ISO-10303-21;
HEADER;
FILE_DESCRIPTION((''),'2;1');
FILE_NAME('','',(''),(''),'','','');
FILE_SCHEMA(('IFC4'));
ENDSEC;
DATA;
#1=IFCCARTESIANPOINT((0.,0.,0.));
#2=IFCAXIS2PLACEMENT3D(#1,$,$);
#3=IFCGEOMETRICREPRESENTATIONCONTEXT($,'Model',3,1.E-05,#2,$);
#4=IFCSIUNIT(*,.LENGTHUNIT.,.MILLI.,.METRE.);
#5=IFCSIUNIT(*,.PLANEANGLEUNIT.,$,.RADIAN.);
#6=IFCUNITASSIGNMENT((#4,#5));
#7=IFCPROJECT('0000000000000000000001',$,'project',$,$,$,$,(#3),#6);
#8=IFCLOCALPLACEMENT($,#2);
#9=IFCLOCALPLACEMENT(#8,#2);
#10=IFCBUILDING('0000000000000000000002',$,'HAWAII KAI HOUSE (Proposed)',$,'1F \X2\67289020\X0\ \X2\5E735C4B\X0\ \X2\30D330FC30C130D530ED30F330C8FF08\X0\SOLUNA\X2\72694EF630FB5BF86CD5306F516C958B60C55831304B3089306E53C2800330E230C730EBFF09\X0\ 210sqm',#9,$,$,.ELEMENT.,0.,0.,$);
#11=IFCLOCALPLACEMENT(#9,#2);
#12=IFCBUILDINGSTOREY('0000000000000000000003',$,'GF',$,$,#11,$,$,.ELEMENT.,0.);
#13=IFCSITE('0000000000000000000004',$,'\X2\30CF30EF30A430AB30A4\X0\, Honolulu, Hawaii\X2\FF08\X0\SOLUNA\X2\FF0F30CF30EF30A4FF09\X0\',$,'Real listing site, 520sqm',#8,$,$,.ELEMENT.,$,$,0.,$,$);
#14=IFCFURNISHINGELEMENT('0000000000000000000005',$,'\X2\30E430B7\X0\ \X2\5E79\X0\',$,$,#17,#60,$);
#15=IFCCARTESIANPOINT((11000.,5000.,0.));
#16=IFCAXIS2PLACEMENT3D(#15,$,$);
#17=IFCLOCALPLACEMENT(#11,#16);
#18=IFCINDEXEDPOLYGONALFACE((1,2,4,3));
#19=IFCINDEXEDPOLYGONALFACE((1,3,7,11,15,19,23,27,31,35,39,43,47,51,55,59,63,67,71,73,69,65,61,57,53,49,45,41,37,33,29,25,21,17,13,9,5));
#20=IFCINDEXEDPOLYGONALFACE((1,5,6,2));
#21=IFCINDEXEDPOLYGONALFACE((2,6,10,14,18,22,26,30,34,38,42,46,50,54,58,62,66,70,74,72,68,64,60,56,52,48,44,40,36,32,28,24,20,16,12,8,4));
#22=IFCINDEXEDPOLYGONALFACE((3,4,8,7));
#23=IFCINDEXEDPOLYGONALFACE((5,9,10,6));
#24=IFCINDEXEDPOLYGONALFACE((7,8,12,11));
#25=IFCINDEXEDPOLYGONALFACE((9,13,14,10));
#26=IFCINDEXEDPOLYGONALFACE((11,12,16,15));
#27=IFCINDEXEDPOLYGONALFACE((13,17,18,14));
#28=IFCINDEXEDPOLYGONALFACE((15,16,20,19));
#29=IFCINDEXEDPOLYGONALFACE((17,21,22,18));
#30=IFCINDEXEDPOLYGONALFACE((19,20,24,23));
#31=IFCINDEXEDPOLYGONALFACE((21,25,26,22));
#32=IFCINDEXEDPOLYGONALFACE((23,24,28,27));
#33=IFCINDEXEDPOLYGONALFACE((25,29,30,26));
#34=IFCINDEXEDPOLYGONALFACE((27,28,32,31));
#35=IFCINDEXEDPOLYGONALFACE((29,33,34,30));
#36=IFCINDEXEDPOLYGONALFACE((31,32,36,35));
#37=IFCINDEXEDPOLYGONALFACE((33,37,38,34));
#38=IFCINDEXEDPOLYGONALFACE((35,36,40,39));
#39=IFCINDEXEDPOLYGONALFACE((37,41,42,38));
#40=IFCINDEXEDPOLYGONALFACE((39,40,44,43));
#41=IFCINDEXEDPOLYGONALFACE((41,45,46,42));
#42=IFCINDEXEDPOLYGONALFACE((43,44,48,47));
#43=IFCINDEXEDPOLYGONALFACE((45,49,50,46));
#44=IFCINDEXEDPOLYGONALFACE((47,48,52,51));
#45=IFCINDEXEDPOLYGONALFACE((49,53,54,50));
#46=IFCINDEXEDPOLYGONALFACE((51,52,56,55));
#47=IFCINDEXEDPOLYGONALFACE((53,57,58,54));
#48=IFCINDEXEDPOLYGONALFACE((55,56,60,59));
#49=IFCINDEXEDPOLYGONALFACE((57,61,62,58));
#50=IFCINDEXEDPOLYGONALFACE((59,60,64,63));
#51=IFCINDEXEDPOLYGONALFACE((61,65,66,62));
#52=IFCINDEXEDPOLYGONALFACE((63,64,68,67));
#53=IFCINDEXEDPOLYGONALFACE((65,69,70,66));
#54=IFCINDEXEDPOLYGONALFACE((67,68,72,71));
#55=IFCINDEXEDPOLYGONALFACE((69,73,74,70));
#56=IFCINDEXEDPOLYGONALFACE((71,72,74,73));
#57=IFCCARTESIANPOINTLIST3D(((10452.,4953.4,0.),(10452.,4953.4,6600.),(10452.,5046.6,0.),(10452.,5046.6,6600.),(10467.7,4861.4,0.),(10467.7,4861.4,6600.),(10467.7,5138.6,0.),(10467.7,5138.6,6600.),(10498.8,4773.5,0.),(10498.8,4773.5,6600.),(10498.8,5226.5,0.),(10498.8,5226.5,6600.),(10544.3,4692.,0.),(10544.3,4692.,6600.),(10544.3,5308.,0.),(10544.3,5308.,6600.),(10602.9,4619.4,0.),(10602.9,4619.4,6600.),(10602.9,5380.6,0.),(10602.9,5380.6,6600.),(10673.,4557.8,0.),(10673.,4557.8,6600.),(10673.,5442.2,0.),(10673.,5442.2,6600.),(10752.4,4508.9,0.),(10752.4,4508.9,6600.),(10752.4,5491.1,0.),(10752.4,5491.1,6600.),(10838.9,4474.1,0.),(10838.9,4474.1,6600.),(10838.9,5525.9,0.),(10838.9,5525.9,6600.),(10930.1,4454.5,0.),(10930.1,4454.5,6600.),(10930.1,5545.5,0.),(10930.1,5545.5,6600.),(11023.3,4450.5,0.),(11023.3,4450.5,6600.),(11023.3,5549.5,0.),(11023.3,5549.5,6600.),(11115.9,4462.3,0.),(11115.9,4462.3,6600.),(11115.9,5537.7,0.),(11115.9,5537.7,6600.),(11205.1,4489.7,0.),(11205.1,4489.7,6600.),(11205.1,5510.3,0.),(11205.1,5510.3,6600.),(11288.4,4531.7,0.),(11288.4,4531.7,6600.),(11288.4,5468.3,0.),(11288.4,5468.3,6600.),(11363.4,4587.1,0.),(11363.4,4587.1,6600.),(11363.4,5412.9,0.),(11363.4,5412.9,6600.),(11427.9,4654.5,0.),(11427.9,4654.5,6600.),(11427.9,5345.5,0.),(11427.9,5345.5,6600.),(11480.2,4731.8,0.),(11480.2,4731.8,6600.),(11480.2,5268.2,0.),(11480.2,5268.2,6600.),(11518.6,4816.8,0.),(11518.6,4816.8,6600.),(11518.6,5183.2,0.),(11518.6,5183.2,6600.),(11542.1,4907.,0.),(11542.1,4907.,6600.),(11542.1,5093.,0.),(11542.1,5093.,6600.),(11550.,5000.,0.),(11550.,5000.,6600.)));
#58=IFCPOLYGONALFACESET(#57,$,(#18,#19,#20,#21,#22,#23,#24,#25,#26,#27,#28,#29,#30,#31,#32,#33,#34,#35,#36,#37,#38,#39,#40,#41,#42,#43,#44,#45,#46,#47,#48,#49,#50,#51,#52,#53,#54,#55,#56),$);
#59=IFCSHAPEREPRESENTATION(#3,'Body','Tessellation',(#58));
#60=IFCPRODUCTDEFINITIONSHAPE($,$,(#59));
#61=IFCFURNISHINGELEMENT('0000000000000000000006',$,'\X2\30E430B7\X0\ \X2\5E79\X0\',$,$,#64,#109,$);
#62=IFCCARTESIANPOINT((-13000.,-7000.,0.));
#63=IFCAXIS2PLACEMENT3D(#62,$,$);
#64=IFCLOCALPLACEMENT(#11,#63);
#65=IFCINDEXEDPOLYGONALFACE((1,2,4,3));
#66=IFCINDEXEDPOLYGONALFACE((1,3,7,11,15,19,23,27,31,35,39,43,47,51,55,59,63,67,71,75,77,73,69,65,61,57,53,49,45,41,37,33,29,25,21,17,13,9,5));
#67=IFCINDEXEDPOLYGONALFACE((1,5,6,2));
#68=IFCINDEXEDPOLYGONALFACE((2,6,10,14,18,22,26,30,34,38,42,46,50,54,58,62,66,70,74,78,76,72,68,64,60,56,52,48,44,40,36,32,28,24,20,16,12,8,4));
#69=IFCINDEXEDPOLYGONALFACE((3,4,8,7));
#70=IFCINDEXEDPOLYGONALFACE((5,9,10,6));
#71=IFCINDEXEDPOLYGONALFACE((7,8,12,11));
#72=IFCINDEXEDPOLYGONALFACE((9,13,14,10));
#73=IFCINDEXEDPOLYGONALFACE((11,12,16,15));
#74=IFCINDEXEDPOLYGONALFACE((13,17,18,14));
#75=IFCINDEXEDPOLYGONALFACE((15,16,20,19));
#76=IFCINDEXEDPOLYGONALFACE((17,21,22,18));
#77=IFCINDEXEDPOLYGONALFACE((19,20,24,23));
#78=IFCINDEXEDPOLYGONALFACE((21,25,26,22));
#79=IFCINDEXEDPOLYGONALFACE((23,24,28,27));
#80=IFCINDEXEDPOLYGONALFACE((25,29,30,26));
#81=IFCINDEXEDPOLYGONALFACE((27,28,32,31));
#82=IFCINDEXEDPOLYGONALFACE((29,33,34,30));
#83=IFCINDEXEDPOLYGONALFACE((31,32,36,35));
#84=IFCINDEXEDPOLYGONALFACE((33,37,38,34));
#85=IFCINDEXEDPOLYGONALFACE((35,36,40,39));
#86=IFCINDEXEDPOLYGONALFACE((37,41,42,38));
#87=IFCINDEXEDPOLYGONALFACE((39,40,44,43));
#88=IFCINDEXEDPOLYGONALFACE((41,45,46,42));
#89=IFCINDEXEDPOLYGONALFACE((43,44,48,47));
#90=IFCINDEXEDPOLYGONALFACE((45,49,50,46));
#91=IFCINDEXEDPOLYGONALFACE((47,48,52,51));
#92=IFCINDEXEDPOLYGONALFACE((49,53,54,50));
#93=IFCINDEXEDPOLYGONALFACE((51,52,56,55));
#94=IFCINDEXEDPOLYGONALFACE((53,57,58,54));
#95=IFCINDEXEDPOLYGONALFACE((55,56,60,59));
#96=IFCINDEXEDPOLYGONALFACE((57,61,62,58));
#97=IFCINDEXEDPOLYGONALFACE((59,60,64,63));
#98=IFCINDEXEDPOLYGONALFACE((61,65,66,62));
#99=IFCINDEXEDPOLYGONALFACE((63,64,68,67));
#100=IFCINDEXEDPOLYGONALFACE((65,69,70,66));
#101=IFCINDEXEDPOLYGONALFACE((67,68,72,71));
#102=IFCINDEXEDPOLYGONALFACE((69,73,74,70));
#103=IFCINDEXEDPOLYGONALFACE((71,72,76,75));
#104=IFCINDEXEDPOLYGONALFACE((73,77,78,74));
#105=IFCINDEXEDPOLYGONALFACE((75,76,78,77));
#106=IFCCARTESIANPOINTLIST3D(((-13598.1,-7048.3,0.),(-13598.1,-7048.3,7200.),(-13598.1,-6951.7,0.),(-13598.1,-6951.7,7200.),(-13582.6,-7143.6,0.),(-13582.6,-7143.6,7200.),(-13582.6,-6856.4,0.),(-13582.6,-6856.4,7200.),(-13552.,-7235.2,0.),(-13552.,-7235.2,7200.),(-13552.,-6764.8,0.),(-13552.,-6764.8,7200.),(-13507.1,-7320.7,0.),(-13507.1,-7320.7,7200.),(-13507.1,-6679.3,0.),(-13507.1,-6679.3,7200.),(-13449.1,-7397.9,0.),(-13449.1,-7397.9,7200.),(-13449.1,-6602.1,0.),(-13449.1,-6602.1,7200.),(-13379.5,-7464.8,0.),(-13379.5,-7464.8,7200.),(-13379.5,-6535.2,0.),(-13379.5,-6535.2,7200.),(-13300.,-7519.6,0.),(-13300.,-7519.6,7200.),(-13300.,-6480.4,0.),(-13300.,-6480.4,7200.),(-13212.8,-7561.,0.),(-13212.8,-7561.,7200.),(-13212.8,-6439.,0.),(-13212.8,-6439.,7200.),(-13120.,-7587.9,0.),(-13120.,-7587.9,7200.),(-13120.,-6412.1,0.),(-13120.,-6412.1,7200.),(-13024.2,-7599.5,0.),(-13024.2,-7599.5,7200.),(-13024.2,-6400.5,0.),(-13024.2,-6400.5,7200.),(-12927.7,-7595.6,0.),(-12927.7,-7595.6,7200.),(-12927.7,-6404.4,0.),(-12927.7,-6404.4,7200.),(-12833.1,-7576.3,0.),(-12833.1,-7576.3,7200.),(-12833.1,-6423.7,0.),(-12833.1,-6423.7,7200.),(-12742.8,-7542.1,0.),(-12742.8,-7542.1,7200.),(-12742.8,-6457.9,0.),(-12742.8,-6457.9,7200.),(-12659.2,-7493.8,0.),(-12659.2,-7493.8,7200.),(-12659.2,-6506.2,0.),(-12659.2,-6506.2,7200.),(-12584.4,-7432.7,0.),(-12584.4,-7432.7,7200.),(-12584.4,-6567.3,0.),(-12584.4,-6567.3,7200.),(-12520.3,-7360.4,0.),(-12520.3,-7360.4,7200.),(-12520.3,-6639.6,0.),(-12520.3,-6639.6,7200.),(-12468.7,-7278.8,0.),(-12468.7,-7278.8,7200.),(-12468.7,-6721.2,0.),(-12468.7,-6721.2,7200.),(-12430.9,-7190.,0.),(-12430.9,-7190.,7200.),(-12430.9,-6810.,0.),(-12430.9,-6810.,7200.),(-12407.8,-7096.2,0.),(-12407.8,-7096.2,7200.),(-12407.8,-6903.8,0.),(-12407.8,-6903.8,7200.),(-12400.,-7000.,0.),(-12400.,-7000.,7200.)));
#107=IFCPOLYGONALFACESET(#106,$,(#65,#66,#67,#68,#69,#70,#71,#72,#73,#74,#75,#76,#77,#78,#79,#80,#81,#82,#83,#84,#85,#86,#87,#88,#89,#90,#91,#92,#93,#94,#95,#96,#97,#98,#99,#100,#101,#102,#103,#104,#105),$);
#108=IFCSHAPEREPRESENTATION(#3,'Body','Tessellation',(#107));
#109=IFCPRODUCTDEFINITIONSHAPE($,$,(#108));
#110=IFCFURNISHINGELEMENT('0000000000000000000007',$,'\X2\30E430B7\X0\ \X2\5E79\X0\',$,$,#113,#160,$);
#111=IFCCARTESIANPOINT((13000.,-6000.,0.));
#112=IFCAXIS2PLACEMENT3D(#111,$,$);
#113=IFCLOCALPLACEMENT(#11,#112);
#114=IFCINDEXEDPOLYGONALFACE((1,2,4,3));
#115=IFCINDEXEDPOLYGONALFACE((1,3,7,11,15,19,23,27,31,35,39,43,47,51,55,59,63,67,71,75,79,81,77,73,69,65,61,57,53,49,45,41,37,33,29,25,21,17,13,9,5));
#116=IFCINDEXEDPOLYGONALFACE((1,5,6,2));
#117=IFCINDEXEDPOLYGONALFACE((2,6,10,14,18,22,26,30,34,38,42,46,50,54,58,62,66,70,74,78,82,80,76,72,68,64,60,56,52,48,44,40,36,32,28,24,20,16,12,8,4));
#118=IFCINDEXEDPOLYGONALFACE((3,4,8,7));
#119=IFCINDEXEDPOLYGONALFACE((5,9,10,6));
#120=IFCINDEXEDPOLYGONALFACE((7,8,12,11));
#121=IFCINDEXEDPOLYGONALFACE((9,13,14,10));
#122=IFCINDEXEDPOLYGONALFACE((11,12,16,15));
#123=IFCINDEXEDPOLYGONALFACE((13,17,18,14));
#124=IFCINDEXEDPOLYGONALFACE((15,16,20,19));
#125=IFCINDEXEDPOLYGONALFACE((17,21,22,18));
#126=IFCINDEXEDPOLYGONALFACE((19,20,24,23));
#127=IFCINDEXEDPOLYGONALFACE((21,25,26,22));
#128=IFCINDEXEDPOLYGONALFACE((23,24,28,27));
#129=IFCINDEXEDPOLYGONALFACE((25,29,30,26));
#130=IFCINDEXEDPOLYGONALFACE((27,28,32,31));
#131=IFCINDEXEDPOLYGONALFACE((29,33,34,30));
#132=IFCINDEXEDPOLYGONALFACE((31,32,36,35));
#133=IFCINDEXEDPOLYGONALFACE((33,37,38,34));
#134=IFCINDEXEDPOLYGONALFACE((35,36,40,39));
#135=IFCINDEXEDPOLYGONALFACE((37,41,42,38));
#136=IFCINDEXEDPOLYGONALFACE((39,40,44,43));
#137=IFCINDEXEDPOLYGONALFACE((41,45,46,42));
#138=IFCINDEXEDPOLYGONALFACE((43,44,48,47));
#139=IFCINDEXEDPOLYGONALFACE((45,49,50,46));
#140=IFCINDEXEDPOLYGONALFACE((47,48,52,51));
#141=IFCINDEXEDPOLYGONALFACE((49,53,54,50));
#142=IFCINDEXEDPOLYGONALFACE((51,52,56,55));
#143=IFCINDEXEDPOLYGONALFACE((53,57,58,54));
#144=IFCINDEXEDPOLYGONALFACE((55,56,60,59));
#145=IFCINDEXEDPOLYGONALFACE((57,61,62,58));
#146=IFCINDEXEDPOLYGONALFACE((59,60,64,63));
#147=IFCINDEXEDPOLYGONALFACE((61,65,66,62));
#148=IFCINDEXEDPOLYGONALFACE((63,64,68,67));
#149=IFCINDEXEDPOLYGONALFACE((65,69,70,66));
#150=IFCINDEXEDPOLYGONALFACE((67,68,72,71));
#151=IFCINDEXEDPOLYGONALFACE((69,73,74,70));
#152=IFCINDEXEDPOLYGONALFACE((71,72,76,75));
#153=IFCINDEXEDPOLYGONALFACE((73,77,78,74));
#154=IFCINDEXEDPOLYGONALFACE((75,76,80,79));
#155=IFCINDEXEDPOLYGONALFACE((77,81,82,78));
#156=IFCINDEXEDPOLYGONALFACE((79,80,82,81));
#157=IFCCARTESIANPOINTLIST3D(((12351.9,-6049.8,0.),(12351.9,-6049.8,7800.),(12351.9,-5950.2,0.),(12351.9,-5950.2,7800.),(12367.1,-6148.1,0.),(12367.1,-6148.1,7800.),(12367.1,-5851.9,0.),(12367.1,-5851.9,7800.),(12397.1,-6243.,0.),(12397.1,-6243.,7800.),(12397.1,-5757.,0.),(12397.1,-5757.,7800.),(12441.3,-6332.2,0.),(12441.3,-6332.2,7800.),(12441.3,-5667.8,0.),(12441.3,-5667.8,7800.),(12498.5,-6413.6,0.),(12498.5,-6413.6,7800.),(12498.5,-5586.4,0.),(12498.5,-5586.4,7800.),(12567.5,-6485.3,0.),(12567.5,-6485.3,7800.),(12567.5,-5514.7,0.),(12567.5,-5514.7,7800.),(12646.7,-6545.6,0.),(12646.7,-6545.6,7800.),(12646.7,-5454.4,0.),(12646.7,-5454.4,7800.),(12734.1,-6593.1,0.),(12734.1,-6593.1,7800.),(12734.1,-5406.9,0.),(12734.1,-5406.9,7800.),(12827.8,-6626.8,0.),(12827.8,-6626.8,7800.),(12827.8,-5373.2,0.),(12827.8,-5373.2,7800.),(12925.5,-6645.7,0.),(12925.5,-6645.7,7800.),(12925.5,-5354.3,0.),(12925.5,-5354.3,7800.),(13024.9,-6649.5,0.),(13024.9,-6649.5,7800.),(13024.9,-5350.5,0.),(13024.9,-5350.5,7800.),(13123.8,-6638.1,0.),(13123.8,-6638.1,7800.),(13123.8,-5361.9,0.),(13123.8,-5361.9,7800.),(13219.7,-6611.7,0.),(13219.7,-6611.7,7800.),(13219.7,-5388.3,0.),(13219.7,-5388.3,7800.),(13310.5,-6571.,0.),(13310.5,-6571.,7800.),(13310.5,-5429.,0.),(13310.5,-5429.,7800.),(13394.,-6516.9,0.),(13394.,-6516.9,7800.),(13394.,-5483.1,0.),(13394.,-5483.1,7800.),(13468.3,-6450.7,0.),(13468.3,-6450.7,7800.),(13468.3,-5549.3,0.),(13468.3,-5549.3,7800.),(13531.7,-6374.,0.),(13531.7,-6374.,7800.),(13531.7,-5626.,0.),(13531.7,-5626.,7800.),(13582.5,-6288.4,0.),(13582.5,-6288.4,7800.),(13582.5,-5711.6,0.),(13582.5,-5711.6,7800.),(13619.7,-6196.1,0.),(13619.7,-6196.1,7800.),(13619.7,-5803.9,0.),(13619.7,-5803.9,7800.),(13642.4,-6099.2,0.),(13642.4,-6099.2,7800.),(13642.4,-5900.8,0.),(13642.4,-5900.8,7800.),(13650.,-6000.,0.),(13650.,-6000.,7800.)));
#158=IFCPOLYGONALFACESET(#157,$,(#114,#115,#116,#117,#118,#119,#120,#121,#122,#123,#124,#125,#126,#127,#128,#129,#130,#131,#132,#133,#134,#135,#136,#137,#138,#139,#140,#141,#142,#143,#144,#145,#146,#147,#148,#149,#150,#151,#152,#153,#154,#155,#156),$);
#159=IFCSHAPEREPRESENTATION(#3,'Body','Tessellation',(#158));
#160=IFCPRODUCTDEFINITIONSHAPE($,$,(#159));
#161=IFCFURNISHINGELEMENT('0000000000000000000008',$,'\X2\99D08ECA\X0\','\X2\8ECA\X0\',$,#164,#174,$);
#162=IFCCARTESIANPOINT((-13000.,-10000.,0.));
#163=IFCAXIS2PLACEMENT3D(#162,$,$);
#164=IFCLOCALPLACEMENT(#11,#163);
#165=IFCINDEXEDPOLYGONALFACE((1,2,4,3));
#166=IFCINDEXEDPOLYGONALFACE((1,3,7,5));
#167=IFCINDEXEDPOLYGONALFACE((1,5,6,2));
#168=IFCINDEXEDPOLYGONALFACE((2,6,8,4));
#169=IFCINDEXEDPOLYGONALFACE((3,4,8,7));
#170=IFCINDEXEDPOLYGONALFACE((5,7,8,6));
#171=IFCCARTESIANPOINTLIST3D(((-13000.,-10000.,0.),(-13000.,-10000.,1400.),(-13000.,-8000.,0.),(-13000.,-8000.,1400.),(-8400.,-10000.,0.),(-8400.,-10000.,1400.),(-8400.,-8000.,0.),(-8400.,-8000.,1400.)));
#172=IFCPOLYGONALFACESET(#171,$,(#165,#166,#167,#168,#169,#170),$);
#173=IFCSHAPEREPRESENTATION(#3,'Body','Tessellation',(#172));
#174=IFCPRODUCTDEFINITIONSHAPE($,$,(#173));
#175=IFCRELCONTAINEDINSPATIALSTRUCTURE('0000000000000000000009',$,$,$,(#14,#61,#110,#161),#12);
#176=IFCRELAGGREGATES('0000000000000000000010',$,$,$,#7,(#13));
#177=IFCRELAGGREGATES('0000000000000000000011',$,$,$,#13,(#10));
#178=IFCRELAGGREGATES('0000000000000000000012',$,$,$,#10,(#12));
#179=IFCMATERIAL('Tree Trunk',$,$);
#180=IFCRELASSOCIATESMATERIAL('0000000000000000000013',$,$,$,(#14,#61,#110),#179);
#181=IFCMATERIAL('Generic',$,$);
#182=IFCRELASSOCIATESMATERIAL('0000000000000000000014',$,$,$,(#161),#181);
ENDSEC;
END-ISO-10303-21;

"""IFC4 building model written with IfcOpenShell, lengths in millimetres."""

from ifc_helpers import new_model, si_unit, frame, frame_2d, origin, origin_2d, place, context, project, spatial, rectangle, circle, extrude, material, element, save


model = new_model("IFC4")

# Units and contexts
model_context = context("Model", 3, precision=1e-05, world=origin())
ifc_project = project(units=[si_unit("LENGTHUNIT", "METRE", prefix="MILLI"), si_unit("PLANEANGLEUNIT", "RADIAN")], contexts=[model_context])

# Site, building, storey
site_placement = place(None, origin())
site = spatial("IfcSite", under=ifc_project, at=site_placement, Name="ハワイカイ, Honolulu, Hawaii（SOLUNA／ハワイ）", ObjectType="Real listing site, 520sqm", CompositionType="ELEMENT", RefElevation=0.0)
building_placement = place(site_placement, origin())
building = spatial("IfcBuilding", under=site, at=building_placement, Name="HAWAII KAI HOUSE (Proposed)", ObjectType="1F 木造 平屋 ビーチフロント（SOLUNA物件・寸法は公開情報からの参考モデル） 210sqm", CompositionType="ELEMENT", ElevationOfRefHeight=0.0, ElevationOfTerrain=0.0)
storey_placement = place(building_placement, origin())
storey = spatial("IfcBuildingStorey", under=building, at=storey_placement, Name="GF", CompositionType="ELEMENT", Elevation=0.0)

# Shared definitions
ifc_material_1 = material(Name="Generic")

# Furnishing elements
ifc_material_2 = material(Name="Tree Trunk")
furnishing_1_placement = place(storey_placement, frame((11000.0, 5000.0, 0.0)))
element("IfcFurnishingElement", 1, at=furnishing_1_placement, inside=storey, material=ifc_material_2, Name="ヤシ 幹", context=model_context, shape_type="SweptSolid", body=[
    extrude(circle(Radius=550.0, at=origin_2d()), frame((11000.0, 5000.0, 0.0)), (0.0, 0.0, 1.0), 6600.0),
])
furnishing_2_placement = place(storey_placement, frame((-13000.0, -7000.0, 0.0)))
element("IfcFurnishingElement", 2, at=furnishing_2_placement, inside=storey, material=ifc_material_2, Name="ヤシ 幹", context=model_context, shape_type="SweptSolid", body=[
    extrude(circle(Radius=600.0, at=origin_2d()), frame((-13000.0, -7000.0, 0.0)), (0.0, 0.0, 1.0), 7200.0),
])
furnishing_3_placement = place(storey_placement, frame((13000.0, -6000.0, 0.0)))
element("IfcFurnishingElement", 3, at=furnishing_3_placement, inside=storey, material=ifc_material_2, Name="ヤシ 幹", context=model_context, shape_type="SweptSolid", body=[
    extrude(circle(Radius=650.0, at=origin_2d()), frame((13000.0, -6000.0, 0.0)), (0.0, 0.0, 1.0), 7800.0),
])
furnishing_4_placement = place(storey_placement, frame((-13000.0, -10000.0, 0.0)))
element("IfcFurnishingElement", 4, at=furnishing_4_placement, inside=storey, material=ifc_material_1, Name="駐車", Description="車", context=model_context, shape_type="SweptSolid", body=[
    extrude(rectangle(XDim=4600.0, YDim=2000.0, at=frame_2d((2300.0, 1000.0))), frame((-13000.0, -10000.0, 0.0)), (0.0, 0.0, 1.0), 1400.0),
])

save(model, "model.ifc")
